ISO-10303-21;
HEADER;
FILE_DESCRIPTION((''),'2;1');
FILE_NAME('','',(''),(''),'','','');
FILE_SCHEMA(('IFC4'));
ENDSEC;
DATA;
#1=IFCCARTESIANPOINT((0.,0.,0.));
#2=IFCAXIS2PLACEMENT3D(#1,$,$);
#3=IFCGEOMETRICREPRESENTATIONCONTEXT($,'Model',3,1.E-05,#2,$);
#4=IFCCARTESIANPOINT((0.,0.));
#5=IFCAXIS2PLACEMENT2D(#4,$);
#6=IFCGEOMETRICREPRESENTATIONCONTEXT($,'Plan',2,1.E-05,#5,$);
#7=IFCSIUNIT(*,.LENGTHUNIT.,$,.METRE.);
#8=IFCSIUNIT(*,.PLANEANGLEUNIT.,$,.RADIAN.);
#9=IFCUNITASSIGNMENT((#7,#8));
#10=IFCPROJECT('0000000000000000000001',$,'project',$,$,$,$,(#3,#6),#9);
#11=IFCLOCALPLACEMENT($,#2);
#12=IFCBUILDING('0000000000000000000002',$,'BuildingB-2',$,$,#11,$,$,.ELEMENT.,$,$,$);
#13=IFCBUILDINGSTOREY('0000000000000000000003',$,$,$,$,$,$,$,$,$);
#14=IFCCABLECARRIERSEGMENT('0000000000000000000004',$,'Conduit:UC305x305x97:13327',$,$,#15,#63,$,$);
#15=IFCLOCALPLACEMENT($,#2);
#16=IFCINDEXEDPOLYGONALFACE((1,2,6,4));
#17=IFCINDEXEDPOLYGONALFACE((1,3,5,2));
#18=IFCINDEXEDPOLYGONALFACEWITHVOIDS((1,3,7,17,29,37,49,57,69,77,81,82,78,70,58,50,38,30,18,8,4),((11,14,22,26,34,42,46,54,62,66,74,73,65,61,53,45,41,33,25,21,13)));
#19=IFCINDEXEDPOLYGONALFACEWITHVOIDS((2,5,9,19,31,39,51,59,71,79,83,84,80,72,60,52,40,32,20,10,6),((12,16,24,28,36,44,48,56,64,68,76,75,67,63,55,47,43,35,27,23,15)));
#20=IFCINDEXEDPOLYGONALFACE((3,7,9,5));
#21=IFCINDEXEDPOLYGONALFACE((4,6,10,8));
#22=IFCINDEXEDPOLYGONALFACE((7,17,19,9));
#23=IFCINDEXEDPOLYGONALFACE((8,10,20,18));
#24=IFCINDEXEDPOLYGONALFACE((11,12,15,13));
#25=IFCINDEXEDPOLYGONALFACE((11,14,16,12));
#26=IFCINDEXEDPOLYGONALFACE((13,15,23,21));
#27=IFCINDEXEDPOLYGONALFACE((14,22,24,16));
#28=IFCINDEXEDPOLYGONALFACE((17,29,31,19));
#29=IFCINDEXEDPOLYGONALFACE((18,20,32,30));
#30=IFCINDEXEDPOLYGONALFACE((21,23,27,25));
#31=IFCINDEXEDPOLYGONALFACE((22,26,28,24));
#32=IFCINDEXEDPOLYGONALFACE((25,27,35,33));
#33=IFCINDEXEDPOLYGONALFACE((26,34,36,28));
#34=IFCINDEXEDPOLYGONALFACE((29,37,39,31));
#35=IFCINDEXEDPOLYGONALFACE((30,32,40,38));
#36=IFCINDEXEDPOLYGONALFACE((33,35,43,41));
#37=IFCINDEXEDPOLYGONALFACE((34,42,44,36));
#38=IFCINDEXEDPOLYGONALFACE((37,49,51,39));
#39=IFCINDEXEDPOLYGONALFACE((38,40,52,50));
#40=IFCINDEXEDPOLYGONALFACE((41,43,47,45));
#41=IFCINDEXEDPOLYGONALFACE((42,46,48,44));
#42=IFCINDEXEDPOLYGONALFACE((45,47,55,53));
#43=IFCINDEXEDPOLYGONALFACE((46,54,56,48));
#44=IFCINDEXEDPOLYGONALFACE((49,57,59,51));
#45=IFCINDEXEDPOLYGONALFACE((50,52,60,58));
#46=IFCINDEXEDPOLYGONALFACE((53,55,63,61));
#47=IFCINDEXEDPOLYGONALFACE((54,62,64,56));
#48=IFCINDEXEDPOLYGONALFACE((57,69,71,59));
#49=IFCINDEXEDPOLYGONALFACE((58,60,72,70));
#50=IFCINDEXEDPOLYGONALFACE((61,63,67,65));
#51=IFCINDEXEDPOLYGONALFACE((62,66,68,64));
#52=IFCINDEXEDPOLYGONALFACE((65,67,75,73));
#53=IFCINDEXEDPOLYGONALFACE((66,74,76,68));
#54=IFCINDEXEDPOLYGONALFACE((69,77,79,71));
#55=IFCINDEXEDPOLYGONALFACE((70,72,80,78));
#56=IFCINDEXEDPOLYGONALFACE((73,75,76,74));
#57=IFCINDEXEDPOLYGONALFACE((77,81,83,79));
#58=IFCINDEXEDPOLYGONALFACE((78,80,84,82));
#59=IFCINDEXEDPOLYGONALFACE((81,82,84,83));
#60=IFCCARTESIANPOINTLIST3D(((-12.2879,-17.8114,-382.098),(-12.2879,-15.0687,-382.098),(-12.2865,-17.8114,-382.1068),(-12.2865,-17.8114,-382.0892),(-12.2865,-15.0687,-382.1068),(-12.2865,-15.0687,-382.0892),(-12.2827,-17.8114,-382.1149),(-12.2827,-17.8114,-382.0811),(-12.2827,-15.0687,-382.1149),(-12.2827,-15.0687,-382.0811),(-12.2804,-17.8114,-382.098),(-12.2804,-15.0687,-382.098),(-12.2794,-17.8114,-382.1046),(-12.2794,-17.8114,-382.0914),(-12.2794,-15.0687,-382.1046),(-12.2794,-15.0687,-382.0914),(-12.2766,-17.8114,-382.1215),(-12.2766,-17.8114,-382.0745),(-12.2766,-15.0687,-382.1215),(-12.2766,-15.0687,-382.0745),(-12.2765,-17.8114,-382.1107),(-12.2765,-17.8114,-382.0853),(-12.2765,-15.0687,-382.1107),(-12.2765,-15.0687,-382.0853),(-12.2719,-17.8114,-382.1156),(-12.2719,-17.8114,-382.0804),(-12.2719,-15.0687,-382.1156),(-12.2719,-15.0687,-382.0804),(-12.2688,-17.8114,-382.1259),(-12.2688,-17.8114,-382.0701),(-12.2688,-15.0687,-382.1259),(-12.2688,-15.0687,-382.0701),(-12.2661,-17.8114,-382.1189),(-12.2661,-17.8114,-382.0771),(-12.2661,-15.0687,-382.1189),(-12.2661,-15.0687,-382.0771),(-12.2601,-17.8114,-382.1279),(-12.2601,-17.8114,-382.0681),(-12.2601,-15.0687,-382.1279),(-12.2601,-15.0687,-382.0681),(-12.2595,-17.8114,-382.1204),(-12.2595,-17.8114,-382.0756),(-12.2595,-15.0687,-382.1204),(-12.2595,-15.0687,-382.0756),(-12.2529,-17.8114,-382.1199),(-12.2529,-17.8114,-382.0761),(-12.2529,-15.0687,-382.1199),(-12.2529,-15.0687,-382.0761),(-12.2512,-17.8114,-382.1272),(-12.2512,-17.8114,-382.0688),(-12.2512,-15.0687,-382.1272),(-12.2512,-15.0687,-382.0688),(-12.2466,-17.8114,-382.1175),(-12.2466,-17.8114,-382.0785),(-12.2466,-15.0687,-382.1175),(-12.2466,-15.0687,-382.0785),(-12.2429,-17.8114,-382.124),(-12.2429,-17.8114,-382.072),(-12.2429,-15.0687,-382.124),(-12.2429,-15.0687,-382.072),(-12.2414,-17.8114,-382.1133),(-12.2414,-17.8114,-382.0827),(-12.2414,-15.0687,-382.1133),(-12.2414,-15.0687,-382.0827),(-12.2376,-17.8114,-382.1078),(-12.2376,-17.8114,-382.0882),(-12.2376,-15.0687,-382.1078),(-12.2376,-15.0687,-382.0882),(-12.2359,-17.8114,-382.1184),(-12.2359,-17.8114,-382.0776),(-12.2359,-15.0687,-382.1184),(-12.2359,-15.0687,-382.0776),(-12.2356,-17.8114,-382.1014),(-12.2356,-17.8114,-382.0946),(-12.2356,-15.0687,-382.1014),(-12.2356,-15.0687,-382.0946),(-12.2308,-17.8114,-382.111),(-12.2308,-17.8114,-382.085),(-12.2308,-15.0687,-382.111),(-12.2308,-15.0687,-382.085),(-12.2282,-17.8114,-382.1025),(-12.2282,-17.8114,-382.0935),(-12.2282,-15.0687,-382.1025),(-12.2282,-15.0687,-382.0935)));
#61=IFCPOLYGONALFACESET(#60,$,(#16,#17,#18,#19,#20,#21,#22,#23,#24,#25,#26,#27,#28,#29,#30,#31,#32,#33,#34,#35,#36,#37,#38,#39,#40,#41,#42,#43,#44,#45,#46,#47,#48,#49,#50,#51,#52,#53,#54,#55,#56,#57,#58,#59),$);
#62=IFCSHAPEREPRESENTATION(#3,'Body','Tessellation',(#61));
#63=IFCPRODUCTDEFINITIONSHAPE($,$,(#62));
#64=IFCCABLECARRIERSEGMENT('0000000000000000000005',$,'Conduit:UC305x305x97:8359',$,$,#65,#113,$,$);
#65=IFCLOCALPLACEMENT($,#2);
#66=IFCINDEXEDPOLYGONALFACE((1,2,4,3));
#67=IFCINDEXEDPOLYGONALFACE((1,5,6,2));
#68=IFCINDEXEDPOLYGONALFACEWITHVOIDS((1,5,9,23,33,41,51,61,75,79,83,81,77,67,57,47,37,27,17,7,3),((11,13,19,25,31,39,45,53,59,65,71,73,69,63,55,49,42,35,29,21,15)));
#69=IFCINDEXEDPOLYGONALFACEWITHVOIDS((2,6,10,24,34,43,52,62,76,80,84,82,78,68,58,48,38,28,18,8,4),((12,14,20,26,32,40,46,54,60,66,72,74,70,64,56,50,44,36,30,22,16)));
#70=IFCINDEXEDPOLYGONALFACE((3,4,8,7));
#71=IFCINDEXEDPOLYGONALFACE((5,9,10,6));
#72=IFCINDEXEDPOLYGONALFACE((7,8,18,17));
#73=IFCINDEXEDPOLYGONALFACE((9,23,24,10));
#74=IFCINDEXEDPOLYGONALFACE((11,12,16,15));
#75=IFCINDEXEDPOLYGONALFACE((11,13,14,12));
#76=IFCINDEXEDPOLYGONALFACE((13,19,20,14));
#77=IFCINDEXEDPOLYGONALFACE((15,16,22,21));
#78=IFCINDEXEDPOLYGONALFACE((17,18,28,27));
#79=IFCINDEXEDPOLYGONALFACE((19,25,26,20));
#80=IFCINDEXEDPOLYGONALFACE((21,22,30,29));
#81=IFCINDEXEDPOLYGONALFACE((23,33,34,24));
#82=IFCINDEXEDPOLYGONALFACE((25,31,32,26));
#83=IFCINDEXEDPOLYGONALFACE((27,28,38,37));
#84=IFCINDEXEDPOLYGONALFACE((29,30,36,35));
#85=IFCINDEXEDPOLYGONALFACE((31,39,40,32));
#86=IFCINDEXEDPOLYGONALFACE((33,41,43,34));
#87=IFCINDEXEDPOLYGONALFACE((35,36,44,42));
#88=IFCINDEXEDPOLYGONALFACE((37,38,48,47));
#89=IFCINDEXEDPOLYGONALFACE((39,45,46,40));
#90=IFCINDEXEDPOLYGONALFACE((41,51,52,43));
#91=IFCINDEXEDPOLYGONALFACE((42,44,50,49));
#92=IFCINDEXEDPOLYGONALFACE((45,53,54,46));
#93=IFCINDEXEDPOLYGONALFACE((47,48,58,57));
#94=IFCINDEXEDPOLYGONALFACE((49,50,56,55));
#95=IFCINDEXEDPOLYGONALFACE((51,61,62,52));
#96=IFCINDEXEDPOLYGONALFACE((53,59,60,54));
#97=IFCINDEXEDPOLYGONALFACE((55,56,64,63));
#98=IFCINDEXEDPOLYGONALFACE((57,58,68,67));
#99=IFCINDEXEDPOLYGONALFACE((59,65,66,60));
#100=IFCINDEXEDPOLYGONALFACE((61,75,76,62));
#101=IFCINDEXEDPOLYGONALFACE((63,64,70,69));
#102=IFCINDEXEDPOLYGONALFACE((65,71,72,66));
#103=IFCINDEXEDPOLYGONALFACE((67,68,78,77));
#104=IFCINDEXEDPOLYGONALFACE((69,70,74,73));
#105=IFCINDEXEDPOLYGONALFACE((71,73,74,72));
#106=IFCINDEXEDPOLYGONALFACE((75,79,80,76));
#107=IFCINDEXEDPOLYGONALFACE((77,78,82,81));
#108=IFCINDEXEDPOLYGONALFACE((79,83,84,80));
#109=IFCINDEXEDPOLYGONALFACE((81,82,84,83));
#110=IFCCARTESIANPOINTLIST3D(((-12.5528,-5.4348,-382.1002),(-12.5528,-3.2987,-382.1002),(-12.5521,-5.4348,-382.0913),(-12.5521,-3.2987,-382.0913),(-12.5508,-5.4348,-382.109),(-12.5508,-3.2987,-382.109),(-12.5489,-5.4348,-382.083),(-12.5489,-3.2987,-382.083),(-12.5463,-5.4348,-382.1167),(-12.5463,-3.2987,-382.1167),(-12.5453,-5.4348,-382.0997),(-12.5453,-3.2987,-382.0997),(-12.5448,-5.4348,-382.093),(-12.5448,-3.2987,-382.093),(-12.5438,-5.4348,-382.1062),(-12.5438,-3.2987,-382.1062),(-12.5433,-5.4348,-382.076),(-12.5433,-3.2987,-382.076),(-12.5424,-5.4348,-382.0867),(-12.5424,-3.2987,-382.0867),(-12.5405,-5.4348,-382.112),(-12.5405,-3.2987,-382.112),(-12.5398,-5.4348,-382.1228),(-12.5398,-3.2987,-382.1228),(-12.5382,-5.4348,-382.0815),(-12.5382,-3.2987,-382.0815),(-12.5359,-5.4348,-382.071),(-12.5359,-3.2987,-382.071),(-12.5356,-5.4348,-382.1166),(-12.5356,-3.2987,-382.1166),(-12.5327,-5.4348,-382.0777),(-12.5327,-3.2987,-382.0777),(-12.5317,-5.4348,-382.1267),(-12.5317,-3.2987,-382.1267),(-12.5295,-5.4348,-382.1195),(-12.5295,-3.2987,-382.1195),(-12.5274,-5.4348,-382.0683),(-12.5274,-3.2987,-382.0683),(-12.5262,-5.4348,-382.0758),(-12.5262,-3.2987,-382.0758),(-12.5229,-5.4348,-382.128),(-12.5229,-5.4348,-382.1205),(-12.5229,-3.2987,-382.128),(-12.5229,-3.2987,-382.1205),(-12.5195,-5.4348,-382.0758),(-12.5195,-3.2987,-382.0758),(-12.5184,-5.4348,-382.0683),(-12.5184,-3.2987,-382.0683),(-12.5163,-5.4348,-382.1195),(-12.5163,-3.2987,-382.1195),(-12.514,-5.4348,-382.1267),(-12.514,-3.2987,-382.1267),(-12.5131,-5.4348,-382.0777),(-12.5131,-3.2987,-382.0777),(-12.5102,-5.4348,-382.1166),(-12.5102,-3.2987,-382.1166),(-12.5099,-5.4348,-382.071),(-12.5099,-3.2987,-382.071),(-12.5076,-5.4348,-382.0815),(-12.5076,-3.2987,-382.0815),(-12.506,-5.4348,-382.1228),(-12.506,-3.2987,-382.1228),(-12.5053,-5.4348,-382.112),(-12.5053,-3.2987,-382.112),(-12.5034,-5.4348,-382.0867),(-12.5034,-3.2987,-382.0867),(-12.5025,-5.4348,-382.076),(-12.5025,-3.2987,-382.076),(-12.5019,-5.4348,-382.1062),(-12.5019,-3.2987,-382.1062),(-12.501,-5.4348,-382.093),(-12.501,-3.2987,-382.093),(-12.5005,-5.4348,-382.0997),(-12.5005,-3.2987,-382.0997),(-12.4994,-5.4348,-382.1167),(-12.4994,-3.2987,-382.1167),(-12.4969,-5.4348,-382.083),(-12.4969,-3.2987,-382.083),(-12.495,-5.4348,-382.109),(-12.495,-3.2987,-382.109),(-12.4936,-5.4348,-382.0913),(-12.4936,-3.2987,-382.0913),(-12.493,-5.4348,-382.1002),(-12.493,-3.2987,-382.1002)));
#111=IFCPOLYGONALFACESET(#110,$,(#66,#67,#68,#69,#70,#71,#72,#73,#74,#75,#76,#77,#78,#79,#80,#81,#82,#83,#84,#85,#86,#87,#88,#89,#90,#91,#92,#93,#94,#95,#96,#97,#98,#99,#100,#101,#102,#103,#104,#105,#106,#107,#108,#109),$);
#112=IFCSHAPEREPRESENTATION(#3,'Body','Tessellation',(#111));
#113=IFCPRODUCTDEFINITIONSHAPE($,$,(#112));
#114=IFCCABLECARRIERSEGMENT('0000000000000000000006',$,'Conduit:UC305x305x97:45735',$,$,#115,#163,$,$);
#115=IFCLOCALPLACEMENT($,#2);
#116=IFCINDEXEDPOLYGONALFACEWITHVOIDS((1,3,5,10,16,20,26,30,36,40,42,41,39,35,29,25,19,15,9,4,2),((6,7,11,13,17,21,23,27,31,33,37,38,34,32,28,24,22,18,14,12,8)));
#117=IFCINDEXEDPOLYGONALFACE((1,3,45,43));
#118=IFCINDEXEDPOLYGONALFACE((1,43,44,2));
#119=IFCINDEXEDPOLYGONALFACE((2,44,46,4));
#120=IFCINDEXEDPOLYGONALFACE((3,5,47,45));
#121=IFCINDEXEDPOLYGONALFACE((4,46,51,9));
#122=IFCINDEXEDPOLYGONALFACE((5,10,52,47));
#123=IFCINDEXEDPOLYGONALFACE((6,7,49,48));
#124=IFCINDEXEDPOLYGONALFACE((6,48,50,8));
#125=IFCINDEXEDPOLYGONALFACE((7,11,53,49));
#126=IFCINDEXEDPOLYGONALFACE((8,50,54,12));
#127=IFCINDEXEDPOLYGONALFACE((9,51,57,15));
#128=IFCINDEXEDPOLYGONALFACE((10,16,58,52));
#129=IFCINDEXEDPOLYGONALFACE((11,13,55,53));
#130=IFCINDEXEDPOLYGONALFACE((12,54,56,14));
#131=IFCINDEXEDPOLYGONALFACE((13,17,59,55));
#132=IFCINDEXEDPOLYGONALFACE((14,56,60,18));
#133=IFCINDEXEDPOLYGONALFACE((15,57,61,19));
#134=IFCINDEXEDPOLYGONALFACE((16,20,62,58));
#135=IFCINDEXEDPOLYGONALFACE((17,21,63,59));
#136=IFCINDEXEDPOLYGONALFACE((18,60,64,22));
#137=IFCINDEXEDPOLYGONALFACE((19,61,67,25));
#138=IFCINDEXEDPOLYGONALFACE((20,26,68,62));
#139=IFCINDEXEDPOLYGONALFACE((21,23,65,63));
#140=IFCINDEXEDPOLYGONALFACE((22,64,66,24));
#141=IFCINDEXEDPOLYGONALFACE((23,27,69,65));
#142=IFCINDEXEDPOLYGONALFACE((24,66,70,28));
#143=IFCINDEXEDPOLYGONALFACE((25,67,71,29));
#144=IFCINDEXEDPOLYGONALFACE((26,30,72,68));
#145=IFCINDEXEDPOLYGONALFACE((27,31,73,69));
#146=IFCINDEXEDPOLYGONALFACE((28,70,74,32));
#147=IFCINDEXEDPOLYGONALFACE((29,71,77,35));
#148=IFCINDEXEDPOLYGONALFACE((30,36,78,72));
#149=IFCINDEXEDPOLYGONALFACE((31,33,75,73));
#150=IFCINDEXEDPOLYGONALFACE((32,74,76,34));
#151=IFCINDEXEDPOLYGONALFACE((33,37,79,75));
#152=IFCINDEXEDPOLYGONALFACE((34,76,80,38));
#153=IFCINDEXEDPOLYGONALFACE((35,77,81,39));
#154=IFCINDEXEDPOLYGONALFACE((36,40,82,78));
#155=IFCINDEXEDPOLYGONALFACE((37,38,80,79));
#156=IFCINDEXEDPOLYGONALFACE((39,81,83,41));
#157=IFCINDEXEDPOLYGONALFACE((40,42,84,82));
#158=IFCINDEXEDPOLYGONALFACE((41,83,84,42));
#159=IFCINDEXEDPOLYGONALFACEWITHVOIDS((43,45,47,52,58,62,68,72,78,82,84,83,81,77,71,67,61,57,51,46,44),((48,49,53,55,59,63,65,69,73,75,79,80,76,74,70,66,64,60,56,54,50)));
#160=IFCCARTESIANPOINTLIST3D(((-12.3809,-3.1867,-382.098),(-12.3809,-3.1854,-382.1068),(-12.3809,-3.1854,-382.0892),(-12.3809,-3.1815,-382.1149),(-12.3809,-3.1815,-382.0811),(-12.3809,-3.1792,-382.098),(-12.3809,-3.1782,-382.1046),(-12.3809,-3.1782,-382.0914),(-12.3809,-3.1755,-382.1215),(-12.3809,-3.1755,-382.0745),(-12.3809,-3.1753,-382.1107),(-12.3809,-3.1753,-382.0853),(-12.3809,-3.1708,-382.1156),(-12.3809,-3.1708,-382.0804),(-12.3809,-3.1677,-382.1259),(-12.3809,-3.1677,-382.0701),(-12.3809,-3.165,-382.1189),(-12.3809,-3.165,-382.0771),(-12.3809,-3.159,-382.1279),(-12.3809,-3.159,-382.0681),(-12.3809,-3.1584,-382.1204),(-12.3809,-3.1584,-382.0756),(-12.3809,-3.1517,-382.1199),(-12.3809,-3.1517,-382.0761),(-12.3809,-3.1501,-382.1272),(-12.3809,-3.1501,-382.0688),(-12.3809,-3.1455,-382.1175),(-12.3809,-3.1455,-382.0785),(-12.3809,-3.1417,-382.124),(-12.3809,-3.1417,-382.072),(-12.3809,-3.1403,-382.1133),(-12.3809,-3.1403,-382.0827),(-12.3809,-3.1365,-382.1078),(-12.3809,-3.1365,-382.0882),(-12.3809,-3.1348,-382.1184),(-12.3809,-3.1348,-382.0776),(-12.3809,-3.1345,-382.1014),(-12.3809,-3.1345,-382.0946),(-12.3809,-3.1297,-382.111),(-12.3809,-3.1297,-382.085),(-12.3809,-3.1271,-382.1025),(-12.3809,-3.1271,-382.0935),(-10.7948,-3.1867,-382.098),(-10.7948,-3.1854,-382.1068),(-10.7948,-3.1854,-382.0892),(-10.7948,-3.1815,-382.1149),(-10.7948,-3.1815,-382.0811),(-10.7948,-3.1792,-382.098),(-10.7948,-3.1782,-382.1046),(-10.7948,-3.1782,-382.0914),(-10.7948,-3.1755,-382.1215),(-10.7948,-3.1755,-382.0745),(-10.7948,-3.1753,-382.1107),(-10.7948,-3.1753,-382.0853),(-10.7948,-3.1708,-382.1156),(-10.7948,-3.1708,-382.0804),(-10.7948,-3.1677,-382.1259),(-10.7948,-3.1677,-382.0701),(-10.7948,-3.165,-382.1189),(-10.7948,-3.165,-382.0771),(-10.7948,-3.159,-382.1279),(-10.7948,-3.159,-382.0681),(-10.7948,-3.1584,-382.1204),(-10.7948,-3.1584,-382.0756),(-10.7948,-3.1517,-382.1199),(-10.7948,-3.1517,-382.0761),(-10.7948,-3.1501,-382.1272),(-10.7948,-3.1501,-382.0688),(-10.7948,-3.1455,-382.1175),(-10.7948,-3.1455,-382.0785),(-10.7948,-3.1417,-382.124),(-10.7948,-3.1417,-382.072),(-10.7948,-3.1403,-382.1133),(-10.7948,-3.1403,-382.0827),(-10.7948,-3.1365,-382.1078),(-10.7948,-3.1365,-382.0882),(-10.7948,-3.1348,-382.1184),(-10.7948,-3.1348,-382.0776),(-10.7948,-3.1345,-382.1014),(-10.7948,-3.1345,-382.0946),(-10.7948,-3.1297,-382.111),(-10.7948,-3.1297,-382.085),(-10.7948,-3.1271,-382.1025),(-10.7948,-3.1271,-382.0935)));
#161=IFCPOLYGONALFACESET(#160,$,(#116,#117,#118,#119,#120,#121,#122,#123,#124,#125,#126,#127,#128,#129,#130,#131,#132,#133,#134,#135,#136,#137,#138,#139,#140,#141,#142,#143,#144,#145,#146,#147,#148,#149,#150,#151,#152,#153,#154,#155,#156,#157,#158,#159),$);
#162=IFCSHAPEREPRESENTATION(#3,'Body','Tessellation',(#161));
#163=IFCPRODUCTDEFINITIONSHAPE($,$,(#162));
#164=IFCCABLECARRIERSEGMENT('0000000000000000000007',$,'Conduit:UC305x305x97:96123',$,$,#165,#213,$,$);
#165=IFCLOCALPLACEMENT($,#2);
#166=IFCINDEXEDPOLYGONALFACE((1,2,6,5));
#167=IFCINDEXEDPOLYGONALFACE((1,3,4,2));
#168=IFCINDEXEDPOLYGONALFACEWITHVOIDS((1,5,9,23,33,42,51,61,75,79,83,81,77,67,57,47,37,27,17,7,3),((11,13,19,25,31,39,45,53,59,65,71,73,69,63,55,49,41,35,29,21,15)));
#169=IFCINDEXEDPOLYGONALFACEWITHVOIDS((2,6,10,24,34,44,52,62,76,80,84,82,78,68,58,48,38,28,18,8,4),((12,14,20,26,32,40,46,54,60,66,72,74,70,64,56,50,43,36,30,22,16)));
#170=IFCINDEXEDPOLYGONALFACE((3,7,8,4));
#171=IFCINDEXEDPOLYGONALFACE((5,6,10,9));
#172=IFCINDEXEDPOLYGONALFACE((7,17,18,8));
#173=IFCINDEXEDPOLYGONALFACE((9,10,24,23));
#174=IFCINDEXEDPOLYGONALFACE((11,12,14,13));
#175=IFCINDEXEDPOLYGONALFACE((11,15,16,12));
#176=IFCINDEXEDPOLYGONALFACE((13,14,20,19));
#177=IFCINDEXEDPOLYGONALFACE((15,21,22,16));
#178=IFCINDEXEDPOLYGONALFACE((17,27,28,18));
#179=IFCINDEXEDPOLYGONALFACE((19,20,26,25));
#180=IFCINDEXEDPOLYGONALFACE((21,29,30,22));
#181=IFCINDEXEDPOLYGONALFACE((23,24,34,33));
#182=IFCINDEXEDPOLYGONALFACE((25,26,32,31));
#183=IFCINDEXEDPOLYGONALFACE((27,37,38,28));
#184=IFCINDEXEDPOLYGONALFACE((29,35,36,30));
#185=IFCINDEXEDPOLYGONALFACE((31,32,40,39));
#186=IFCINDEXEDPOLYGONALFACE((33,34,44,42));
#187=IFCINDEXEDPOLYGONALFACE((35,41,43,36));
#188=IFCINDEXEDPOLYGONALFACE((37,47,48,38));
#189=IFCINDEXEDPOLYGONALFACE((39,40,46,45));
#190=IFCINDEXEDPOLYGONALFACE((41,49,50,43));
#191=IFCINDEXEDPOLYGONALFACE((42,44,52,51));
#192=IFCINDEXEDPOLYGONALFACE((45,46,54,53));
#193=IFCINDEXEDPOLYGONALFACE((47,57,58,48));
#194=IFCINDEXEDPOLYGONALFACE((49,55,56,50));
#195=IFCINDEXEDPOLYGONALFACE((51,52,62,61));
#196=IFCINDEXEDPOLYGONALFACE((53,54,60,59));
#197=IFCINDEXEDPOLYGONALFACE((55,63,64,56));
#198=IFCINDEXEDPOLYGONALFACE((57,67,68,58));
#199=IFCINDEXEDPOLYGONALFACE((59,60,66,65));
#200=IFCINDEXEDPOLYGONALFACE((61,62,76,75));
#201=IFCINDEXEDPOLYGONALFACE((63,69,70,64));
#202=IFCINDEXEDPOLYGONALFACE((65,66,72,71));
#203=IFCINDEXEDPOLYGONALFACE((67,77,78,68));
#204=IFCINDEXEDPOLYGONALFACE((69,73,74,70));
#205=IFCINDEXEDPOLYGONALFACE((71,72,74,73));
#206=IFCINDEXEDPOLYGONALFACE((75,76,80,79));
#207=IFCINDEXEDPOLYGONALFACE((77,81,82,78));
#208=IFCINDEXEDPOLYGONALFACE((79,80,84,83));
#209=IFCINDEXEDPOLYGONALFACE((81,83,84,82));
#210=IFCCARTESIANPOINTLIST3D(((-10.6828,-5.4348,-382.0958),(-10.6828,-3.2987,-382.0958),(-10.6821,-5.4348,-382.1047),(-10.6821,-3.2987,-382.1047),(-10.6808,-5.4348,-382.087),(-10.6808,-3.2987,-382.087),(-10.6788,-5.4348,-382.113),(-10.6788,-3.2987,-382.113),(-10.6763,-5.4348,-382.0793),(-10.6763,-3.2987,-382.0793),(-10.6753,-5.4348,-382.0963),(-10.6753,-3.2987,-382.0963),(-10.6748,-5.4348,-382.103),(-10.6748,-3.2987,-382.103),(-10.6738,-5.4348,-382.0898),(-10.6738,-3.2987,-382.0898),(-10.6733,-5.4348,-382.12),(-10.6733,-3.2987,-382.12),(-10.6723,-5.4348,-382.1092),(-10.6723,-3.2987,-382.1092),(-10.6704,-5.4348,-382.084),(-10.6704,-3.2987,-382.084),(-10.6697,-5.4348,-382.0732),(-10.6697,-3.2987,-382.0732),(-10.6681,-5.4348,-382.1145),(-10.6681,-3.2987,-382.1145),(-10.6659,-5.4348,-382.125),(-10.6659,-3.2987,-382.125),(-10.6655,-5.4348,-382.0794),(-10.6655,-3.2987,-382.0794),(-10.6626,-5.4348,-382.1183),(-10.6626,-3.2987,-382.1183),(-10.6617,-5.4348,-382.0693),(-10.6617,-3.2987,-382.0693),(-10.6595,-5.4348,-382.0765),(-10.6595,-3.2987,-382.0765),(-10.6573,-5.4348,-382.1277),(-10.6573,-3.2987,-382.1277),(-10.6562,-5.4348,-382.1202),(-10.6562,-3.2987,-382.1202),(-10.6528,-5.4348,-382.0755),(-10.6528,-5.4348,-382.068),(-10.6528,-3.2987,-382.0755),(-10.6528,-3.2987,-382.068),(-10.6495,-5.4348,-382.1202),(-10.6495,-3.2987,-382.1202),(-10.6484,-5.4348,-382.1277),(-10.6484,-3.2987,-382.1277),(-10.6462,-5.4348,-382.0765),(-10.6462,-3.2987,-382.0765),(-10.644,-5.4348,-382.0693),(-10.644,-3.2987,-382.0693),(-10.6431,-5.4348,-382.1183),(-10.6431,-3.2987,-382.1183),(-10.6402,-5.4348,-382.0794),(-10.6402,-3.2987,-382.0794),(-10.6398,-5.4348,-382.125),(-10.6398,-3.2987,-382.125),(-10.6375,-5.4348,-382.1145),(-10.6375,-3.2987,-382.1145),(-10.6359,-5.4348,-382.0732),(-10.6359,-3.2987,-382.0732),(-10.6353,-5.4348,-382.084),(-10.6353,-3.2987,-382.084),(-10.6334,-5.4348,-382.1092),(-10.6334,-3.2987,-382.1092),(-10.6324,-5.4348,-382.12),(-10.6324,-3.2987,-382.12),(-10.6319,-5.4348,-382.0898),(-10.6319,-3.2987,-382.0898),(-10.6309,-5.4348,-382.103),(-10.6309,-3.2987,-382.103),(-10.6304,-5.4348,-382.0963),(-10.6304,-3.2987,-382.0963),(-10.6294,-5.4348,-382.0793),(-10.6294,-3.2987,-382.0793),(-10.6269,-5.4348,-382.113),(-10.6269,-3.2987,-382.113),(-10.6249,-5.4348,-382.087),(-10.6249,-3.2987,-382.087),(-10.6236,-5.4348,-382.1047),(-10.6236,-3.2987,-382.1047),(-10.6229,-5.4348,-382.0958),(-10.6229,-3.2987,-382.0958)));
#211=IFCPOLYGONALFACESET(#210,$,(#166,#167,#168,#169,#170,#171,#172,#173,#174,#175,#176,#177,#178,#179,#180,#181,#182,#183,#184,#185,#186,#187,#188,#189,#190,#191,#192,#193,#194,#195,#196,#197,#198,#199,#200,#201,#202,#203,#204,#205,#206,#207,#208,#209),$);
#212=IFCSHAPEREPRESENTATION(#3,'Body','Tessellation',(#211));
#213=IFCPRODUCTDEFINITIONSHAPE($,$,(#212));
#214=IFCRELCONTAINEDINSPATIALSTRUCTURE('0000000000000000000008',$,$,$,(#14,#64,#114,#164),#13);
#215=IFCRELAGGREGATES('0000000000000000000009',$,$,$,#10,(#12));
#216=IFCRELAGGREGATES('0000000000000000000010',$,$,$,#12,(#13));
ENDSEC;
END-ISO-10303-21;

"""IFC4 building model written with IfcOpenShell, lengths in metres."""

from ifc_helpers import new_model, entity, si_unit, origin, origin_2d, place, context, project, spatial, element, save


model = new_model("IFC4")

# Units and contexts
model_context = context("Model", 3, precision=1e-05, world=origin())
plan_context = context("Plan", 2, precision=1e-05, world=origin_2d())
ifc_project = project(units=[si_unit("LENGTHUNIT", "METRE"), si_unit("PLANEANGLEUNIT", "RADIAN")], contexts=[model_context, plan_context])

# Building, storey
building_placement = place(None, origin())
building = spatial("IfcBuilding", under=ifc_project, at=building_placement, Name="BuildingB-2", CompositionType="ELEMENT")
storey = spatial("IfcBuildingStorey", under=building)

# Cable carrier segments
element("IfcCableCarrierSegment", 1, inside=storey, Name="Conduit:UC305x305x97:13327", context=model_context, shape_type="AdvancedSweptSolid", body=[
    entity("IfcSweptDiskSolid", entity("IfcCompositeCurve", [entity("IfcCompositeCurveSegment", "CONTINUOUS", False, entity("IfcPolyline", [entity("IfcCartesianPoint", [12.2579, 17.8114, 382.098]), entity("IfcCartesianPoint", [12.2579, 15.0687, 382.098])]))], False), 0.03, 0.0225),
])
element("IfcCableCarrierSegment", 2, inside=storey, Name="Conduit:UC305x305x97:8359", context=model_context, shape_type="AdvancedSweptSolid", body=[
    entity("IfcSweptDiskSolid", entity("IfcCompositeCurve", [entity("IfcCompositeCurveSegment", "CONTINUOUS", False, entity("IfcPolyline", [entity("IfcCartesianPoint", [12.5229, 5.4348, 382.098]), entity("IfcCartesianPoint", [12.5229, 3.2987, 382.098])]))], False), 0.03, 0.0225),
])
element("IfcCableCarrierSegment", 3, inside=storey, Name="Conduit:UC305x305x97:45735", context=model_context, shape_type="AdvancedSweptSolid", body=[
    entity("IfcSweptDiskSolid", entity("IfcCompositeCurve", [entity("IfcCompositeCurveSegment", "CONTINUOUS", False, entity("IfcPolyline", [entity("IfcCartesianPoint", [12.3809, 3.1567, 382.098]), entity("IfcCartesianPoint", [10.7948, 3.1567, 382.098])]))], False), 0.03, 0.0225),
])
element("IfcCableCarrierSegment", 4, inside=storey, Name="Conduit:UC305x305x97:96123", context=model_context, shape_type="AdvancedSweptSolid", body=[
    entity("IfcSweptDiskSolid", entity("IfcCompositeCurve", [entity("IfcCompositeCurveSegment", "CONTINUOUS", False, entity("IfcPolyline", [entity("IfcCartesianPoint", [10.6528, 3.2987, 382.098]), entity("IfcCartesianPoint", [10.6528, 5.4348, 382.098])]))], False), 0.03, 0.0225),
])

save(model, "model.ifc")
